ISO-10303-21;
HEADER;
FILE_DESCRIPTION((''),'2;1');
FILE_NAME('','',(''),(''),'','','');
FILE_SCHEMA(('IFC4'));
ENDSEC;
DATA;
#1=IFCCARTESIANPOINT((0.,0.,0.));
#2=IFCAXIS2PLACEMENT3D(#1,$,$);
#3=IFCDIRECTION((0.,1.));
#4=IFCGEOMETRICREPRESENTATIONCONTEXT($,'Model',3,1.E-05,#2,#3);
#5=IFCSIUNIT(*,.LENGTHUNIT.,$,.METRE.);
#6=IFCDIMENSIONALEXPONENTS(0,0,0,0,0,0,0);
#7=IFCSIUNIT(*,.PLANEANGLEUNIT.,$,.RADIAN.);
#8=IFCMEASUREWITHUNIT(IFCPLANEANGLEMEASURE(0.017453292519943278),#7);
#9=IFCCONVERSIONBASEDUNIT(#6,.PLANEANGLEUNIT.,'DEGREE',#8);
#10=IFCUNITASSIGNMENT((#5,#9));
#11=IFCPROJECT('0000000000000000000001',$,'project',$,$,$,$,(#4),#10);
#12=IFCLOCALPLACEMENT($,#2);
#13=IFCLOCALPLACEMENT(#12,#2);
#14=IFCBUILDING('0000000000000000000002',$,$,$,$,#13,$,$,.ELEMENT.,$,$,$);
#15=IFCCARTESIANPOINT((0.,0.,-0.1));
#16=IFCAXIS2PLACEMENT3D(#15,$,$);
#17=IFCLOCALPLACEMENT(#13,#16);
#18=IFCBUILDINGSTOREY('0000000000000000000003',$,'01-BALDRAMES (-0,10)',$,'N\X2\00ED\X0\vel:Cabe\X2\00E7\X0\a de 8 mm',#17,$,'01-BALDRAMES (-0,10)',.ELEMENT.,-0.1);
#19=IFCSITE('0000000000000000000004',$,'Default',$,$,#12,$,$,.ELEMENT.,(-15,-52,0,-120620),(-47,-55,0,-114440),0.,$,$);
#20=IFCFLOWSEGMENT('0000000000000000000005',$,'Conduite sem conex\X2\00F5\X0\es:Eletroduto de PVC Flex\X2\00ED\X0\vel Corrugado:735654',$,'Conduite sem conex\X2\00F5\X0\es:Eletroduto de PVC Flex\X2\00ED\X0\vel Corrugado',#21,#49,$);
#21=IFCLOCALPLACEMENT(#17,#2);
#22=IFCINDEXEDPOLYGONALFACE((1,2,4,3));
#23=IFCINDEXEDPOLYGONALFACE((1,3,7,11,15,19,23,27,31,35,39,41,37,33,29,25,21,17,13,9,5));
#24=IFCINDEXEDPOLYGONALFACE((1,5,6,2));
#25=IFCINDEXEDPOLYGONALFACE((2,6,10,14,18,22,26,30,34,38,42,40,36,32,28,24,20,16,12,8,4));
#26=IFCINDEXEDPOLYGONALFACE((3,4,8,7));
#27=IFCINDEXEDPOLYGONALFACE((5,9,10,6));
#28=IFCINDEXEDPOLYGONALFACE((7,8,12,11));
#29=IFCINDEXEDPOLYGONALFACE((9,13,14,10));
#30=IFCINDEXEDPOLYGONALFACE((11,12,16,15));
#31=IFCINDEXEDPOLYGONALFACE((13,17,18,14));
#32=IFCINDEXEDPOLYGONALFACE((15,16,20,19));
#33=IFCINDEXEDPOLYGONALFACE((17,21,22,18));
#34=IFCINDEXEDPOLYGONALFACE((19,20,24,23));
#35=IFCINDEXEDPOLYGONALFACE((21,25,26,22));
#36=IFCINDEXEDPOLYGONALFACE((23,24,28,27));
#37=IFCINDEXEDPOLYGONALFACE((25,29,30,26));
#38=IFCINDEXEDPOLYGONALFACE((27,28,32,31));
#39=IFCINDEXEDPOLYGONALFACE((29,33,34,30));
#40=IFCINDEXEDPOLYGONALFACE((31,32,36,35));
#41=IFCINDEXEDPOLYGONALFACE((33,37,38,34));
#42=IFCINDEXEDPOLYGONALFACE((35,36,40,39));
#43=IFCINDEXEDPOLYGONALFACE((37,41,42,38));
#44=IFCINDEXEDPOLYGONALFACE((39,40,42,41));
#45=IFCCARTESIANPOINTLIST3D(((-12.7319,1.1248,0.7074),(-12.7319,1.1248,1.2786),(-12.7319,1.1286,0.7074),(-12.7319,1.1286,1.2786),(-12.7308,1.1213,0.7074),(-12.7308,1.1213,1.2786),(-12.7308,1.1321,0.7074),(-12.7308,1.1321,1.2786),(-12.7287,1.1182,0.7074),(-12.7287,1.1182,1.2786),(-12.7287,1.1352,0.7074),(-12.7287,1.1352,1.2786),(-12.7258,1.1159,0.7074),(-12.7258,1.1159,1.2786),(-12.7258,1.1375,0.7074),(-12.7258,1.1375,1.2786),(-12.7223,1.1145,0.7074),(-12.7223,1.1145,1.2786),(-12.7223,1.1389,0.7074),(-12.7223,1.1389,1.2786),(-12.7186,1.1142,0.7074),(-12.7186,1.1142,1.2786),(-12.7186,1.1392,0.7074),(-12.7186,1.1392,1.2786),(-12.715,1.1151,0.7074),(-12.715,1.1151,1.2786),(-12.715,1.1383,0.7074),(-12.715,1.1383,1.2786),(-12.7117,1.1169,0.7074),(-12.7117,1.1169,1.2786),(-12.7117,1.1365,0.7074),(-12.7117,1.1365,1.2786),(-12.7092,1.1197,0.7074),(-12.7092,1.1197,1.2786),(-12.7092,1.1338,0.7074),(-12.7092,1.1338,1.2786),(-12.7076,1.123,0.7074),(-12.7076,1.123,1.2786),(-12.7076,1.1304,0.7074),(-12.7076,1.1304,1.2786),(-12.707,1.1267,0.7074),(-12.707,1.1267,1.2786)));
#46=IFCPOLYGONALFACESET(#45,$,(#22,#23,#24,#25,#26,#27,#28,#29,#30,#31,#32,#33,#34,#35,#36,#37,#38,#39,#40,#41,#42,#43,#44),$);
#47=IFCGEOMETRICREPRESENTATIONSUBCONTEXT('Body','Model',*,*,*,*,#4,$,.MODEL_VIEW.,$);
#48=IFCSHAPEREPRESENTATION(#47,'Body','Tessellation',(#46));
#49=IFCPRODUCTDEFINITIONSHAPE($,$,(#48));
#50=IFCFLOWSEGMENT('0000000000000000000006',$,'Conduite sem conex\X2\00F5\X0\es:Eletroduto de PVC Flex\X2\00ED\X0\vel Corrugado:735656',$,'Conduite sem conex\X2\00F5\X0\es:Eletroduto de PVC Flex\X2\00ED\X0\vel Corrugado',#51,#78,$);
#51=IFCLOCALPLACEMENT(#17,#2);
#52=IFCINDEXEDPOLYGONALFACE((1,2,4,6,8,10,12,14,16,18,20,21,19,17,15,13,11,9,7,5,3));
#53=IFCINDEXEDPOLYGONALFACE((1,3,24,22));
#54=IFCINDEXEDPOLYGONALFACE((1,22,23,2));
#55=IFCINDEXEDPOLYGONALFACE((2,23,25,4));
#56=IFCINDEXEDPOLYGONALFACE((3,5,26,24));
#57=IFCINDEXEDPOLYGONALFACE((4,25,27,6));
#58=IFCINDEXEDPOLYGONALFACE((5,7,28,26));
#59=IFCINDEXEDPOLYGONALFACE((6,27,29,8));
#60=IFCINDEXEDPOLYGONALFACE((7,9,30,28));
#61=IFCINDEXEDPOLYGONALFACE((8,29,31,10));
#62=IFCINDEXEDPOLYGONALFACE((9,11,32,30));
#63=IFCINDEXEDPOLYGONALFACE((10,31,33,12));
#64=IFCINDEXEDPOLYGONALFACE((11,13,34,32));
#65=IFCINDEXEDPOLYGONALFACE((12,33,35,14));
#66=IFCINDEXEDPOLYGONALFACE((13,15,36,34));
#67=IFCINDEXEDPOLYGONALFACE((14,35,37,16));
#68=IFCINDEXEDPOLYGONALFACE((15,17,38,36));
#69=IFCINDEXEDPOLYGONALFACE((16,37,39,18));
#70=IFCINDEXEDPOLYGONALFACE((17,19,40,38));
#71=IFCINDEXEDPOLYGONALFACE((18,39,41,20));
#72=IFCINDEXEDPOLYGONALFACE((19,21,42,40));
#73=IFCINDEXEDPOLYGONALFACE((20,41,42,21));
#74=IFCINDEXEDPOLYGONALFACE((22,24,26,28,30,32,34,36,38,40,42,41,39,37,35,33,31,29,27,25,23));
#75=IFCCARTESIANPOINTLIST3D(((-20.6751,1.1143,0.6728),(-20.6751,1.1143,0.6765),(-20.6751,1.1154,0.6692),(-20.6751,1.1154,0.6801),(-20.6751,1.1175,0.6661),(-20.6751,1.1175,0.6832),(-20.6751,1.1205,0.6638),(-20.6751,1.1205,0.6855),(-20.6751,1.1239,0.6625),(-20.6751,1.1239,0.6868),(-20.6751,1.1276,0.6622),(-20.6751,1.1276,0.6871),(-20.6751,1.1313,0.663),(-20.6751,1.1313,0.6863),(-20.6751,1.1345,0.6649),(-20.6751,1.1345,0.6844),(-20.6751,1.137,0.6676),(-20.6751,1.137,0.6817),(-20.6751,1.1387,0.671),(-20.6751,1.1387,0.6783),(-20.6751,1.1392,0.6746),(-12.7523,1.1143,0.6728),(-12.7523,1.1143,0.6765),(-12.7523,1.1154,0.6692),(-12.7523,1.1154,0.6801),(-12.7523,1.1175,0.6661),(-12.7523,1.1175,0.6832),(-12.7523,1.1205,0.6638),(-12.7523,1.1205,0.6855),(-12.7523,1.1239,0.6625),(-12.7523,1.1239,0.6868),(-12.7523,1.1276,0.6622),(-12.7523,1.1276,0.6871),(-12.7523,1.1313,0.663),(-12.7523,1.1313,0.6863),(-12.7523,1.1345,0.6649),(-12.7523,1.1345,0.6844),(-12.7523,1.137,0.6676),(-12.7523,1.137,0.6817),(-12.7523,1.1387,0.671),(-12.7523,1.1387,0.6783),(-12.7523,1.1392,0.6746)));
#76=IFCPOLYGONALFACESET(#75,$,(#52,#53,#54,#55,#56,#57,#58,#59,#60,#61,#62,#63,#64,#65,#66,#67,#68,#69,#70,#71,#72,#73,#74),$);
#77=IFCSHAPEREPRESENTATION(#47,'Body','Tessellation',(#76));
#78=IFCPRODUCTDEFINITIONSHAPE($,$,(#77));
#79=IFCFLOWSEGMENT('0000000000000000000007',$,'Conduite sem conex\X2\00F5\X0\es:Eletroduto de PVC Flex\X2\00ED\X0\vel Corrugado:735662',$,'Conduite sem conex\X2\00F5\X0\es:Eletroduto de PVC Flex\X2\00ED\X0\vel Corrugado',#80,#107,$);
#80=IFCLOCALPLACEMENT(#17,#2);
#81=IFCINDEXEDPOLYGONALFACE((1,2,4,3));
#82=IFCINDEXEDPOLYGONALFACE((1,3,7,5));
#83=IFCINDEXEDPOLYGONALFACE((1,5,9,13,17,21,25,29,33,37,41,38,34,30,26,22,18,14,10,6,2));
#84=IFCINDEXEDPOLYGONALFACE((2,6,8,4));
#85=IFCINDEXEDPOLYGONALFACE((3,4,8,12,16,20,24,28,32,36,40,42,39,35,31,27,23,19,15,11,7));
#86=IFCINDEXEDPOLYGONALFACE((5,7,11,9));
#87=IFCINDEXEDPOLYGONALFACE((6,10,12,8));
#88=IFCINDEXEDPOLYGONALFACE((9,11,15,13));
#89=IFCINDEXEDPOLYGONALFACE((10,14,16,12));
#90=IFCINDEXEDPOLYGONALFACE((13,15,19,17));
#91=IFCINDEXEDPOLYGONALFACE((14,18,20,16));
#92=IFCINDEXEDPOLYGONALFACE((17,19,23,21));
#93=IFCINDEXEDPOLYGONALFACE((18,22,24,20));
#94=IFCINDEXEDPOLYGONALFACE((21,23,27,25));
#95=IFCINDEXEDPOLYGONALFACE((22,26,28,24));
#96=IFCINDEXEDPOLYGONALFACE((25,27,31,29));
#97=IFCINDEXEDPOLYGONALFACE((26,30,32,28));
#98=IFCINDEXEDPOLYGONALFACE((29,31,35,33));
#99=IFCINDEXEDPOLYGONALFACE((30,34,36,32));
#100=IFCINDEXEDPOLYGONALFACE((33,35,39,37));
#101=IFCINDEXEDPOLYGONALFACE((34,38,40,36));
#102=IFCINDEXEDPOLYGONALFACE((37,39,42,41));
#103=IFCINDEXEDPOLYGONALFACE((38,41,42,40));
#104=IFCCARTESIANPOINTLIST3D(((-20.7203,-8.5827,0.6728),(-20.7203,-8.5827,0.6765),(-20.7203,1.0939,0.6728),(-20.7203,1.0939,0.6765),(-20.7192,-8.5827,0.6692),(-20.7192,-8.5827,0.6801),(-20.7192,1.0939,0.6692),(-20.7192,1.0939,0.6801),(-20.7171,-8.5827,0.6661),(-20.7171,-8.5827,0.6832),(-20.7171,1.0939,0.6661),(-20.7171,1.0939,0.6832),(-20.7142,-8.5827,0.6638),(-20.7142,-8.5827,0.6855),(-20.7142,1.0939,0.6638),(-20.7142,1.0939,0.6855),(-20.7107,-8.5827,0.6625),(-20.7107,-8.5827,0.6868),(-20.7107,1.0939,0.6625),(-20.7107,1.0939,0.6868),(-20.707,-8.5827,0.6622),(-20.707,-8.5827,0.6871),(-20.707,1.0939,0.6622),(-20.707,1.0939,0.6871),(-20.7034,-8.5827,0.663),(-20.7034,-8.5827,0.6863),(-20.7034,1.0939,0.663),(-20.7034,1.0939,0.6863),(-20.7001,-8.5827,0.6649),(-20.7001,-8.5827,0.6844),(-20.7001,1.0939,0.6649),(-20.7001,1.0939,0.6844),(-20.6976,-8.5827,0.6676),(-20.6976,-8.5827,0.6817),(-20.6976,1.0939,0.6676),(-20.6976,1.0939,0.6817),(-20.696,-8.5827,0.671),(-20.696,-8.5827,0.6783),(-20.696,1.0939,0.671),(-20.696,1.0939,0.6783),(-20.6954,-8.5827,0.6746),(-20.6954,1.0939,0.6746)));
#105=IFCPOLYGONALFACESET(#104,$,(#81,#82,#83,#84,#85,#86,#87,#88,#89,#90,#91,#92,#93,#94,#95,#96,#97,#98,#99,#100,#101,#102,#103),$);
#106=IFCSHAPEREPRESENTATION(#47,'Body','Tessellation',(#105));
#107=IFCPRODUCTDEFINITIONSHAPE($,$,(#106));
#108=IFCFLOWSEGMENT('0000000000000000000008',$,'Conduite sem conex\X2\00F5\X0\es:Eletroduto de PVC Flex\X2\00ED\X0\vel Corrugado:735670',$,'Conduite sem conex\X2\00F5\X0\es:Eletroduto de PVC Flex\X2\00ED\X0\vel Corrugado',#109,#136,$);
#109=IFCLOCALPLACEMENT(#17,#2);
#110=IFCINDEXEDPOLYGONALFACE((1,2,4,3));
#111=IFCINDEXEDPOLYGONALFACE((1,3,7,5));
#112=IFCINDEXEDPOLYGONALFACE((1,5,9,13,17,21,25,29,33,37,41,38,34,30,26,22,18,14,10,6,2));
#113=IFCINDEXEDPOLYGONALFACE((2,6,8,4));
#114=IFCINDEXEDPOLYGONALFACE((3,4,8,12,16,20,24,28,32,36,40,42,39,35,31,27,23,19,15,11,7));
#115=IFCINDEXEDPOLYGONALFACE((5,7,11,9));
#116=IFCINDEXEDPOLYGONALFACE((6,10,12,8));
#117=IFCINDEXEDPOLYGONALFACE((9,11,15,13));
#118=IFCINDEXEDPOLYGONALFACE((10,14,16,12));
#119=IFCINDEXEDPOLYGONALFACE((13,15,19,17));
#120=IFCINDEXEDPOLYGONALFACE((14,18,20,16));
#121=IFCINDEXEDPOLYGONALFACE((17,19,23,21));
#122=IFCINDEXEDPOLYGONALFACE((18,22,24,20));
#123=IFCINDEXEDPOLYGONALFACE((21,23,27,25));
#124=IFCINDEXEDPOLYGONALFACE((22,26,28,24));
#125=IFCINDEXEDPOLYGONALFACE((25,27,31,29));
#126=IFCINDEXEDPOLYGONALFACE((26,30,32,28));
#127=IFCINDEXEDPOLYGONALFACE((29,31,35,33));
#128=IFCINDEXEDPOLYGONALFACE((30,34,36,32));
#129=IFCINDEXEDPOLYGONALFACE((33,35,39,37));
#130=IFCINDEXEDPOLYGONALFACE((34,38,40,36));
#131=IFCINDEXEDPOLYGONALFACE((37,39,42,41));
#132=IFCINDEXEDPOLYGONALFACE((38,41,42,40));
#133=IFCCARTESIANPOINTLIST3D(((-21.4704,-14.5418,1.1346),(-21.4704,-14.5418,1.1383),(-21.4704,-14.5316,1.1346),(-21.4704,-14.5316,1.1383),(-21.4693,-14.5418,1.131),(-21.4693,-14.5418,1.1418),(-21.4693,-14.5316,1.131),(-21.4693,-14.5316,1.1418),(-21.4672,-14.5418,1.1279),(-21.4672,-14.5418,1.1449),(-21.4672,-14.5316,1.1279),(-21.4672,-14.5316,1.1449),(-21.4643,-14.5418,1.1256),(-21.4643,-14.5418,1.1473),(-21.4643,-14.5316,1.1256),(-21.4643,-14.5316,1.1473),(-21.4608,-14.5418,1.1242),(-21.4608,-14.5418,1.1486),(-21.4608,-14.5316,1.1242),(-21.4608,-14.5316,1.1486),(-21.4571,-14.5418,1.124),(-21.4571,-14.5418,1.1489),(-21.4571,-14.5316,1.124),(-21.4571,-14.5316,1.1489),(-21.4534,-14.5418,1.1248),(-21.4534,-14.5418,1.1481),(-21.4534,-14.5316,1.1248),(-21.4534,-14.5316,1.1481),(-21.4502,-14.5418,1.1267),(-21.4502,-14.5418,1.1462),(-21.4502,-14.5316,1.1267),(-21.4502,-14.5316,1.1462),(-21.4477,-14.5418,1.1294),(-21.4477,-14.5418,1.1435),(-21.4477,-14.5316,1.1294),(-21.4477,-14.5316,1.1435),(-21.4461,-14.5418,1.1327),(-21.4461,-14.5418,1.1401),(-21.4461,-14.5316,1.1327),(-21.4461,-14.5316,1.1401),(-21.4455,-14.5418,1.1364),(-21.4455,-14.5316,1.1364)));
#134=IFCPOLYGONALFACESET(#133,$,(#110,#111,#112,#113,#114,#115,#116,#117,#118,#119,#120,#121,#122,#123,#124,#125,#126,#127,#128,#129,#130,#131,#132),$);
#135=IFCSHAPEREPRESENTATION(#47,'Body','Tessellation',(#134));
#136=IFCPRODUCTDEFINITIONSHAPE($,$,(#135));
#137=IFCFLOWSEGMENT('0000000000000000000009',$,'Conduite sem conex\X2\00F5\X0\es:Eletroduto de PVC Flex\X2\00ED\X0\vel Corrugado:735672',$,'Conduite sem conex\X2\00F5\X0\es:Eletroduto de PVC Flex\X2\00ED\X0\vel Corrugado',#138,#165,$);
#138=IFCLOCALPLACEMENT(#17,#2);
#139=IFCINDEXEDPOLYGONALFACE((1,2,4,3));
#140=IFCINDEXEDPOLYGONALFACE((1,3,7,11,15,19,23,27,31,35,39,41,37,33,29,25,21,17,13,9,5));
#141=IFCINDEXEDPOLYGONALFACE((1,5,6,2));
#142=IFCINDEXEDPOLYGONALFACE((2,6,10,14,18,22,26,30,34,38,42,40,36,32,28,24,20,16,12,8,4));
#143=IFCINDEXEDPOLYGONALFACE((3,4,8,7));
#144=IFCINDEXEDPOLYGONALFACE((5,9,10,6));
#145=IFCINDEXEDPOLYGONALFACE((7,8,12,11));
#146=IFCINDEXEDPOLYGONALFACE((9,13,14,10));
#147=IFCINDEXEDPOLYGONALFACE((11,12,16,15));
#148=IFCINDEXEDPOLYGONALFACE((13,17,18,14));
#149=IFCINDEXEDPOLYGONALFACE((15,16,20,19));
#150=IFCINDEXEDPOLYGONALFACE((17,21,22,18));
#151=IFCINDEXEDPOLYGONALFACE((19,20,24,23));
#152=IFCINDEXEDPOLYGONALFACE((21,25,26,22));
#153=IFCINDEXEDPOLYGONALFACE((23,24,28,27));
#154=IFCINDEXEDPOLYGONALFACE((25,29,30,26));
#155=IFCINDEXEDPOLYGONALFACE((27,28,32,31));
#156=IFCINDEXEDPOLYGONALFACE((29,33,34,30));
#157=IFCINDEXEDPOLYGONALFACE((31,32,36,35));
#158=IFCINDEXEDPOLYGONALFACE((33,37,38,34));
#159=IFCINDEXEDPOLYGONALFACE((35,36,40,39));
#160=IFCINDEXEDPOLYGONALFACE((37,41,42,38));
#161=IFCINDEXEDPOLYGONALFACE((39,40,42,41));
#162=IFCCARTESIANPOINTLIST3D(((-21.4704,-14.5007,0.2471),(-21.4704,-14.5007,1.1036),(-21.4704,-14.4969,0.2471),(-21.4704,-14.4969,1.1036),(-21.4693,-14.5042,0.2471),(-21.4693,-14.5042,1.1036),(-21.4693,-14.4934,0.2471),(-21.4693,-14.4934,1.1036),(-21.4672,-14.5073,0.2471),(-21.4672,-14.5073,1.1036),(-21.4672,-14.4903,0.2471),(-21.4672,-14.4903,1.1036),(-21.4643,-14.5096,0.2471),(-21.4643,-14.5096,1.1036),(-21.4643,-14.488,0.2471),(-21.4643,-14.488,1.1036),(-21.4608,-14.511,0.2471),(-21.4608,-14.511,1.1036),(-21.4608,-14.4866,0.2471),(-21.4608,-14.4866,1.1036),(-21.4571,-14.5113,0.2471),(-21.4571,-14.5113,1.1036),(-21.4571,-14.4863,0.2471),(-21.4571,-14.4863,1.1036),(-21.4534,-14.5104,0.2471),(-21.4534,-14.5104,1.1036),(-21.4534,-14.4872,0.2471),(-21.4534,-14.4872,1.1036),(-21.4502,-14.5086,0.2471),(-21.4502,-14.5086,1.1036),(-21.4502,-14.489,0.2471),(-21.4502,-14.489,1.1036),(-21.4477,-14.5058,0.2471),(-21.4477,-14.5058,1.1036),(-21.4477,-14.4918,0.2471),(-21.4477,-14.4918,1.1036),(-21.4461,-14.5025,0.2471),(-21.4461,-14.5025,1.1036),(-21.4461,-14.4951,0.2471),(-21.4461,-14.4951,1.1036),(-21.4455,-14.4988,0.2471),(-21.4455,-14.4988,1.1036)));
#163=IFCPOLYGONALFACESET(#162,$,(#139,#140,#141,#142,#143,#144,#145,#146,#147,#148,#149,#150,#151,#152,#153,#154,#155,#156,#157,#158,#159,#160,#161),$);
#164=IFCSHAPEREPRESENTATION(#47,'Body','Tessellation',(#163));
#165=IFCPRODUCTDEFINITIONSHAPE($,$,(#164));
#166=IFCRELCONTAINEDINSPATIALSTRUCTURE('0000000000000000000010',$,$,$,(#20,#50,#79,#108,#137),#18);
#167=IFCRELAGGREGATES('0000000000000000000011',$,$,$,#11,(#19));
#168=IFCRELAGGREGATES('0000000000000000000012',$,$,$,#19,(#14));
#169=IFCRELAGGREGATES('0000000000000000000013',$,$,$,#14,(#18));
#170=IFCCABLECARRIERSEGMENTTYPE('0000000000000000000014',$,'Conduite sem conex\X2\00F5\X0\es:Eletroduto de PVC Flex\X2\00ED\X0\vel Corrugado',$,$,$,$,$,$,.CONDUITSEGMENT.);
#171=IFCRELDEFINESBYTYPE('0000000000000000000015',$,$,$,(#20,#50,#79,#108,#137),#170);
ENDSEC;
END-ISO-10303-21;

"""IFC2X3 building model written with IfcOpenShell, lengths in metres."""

from ifc_helpers import new_model, entity, si_unit, converted_unit, direction, frame, frame_2d, origin, origin_2d_with_axis, place, context, subcontext, project, spatial, circle, extrude, type_object, element, save


model = new_model("IFC2X3")

# Units and contexts
model_context = context("Model", 3, precision=1e-05, world=origin(), true_north=direction((0.0, 1.0)))
body_context = subcontext(model_context, "Body", "Model", "MODEL_VIEW")
ifc_project = project(units=[si_unit("LENGTHUNIT", "METRE"), converted_unit("PLANEANGLEUNIT", "DEGREE", entity("IfcPlaneAngleMeasure", 0.017453292519943278), si_unit("PLANEANGLEUNIT", "RADIAN"), dimensions=[0, 0, 0, 0, 0, 0, 0])], contexts=[model_context])

# Site, building, storey
site_placement = place(None, origin())
site = spatial("IfcSite", under=ifc_project, at=site_placement, Name="Default", CompositionType="ELEMENT", RefLatitude=(-15, -52, 0, -120620), RefLongitude=(-47, -55, 0, -114440), RefElevation=0.0)
building_placement = place(site_placement, origin())
building = spatial("IfcBuilding", under=site, at=building_placement, CompositionType="ELEMENT")
storey_placement = place(building_placement, frame((0.0, 0.0, -0.1)))
storey = spatial("IfcBuildingStorey", under=building, at=storey_placement, Name="01-BALDRAMES (-0,10)", ObjectType="Nível:Cabeça de 8 mm", LongName="01-BALDRAMES (-0,10)", CompositionType="ELEMENT", Elevation=-0.1)

# Flow segments
cable_carrier_segment_type = type_object("IfcCableCarrierSegmentType", Name="Conduite sem conexões:Eletroduto de PVC Flexível Corrugado", PredefinedType="CONDUITSEGMENT")
flow_segment_1_placement = place(storey_placement, origin())
element("IfcFlowSegment", 1, at=flow_segment_1_placement, inside=storey, type_object=cable_carrier_segment_type, Name="Conduite sem conexões:Eletroduto de PVC Flexível Corrugado:735654", ObjectType="Conduite sem conexões:Eletroduto de PVC Flexível Corrugado", context=body_context, shape_type="SweptSolid", body=[
    extrude(circle(Radius=0.0125, at=frame_2d((0.0, 0.0), x_axis=(1.0, 0.0))), frame((-12.7195, 1.1267, 0.7074)), (0.0, 0.0, 1.0), 0.5712),
])
flow_segment_2_placement = place(storey_placement, origin())
element("IfcFlowSegment", 2, at=flow_segment_2_placement, inside=storey, type_object=cable_carrier_segment_type, Name="Conduite sem conexões:Eletroduto de PVC Flexível Corrugado:735656", ObjectType="Conduite sem conexões:Eletroduto de PVC Flexível Corrugado", context=body_context, shape_type="SweptSolid", body=[
    extrude(circle(Radius=0.0125, at=origin_2d_with_axis()), frame((-20.6751, 1.1267, 0.6746), z_axis=(1.0, 0.0, 0.0), x_axis=(0.0, 1.0, 0.0)), (0.0, 0.0, 1.0), 7.9228),
])
flow_segment_3_placement = place(storey_placement, origin())
element("IfcFlowSegment", 3, at=flow_segment_3_placement, inside=storey, type_object=cable_carrier_segment_type, Name="Conduite sem conexões:Eletroduto de PVC Flexível Corrugado:735662", ObjectType="Conduite sem conexões:Eletroduto de PVC Flexível Corrugado", context=body_context, shape_type="SweptSolid", body=[
    extrude(circle(Radius=0.0125, at=origin_2d_with_axis()), frame((-20.7079, -8.5827, 0.6746), z_axis=(0.0, 1.0, 0.0), x_axis=(1.0, 0.0, 0.0)), (0.0, 0.0, 1.0), 9.6766),
])
flow_segment_4_placement = place(storey_placement, origin())
element("IfcFlowSegment", 4, at=flow_segment_4_placement, inside=storey, type_object=cable_carrier_segment_type, Name="Conduite sem conexões:Eletroduto de PVC Flexível Corrugado:735670", ObjectType="Conduite sem conexões:Eletroduto de PVC Flexível Corrugado", context=body_context, shape_type="SweptSolid", body=[
    extrude(circle(Radius=0.0125, at=origin_2d_with_axis()), frame((-21.458, -14.5418, 1.1364), z_axis=(0.0, 1.0, 0.0), x_axis=(1.0, 0.0, 0.0)), (0.0, 0.0, 1.0), 0.0102),
])
flow_segment_5_placement = place(storey_placement, origin())
element("IfcFlowSegment", 5, at=flow_segment_5_placement, inside=storey, type_object=cable_carrier_segment_type, Name="Conduite sem conexões:Eletroduto de PVC Flexível Corrugado:735672", ObjectType="Conduite sem conexões:Eletroduto de PVC Flexível Corrugado", context=body_context, shape_type="SweptSolid", body=[
    extrude(circle(Radius=0.0125, at=frame_2d((0.0, 0.0), x_axis=(1.0, 0.0))), frame((-21.458, -14.4988, 0.2471)), (0.0, 0.0, 1.0), 0.8565),
])

save(model, "model.ifc")
